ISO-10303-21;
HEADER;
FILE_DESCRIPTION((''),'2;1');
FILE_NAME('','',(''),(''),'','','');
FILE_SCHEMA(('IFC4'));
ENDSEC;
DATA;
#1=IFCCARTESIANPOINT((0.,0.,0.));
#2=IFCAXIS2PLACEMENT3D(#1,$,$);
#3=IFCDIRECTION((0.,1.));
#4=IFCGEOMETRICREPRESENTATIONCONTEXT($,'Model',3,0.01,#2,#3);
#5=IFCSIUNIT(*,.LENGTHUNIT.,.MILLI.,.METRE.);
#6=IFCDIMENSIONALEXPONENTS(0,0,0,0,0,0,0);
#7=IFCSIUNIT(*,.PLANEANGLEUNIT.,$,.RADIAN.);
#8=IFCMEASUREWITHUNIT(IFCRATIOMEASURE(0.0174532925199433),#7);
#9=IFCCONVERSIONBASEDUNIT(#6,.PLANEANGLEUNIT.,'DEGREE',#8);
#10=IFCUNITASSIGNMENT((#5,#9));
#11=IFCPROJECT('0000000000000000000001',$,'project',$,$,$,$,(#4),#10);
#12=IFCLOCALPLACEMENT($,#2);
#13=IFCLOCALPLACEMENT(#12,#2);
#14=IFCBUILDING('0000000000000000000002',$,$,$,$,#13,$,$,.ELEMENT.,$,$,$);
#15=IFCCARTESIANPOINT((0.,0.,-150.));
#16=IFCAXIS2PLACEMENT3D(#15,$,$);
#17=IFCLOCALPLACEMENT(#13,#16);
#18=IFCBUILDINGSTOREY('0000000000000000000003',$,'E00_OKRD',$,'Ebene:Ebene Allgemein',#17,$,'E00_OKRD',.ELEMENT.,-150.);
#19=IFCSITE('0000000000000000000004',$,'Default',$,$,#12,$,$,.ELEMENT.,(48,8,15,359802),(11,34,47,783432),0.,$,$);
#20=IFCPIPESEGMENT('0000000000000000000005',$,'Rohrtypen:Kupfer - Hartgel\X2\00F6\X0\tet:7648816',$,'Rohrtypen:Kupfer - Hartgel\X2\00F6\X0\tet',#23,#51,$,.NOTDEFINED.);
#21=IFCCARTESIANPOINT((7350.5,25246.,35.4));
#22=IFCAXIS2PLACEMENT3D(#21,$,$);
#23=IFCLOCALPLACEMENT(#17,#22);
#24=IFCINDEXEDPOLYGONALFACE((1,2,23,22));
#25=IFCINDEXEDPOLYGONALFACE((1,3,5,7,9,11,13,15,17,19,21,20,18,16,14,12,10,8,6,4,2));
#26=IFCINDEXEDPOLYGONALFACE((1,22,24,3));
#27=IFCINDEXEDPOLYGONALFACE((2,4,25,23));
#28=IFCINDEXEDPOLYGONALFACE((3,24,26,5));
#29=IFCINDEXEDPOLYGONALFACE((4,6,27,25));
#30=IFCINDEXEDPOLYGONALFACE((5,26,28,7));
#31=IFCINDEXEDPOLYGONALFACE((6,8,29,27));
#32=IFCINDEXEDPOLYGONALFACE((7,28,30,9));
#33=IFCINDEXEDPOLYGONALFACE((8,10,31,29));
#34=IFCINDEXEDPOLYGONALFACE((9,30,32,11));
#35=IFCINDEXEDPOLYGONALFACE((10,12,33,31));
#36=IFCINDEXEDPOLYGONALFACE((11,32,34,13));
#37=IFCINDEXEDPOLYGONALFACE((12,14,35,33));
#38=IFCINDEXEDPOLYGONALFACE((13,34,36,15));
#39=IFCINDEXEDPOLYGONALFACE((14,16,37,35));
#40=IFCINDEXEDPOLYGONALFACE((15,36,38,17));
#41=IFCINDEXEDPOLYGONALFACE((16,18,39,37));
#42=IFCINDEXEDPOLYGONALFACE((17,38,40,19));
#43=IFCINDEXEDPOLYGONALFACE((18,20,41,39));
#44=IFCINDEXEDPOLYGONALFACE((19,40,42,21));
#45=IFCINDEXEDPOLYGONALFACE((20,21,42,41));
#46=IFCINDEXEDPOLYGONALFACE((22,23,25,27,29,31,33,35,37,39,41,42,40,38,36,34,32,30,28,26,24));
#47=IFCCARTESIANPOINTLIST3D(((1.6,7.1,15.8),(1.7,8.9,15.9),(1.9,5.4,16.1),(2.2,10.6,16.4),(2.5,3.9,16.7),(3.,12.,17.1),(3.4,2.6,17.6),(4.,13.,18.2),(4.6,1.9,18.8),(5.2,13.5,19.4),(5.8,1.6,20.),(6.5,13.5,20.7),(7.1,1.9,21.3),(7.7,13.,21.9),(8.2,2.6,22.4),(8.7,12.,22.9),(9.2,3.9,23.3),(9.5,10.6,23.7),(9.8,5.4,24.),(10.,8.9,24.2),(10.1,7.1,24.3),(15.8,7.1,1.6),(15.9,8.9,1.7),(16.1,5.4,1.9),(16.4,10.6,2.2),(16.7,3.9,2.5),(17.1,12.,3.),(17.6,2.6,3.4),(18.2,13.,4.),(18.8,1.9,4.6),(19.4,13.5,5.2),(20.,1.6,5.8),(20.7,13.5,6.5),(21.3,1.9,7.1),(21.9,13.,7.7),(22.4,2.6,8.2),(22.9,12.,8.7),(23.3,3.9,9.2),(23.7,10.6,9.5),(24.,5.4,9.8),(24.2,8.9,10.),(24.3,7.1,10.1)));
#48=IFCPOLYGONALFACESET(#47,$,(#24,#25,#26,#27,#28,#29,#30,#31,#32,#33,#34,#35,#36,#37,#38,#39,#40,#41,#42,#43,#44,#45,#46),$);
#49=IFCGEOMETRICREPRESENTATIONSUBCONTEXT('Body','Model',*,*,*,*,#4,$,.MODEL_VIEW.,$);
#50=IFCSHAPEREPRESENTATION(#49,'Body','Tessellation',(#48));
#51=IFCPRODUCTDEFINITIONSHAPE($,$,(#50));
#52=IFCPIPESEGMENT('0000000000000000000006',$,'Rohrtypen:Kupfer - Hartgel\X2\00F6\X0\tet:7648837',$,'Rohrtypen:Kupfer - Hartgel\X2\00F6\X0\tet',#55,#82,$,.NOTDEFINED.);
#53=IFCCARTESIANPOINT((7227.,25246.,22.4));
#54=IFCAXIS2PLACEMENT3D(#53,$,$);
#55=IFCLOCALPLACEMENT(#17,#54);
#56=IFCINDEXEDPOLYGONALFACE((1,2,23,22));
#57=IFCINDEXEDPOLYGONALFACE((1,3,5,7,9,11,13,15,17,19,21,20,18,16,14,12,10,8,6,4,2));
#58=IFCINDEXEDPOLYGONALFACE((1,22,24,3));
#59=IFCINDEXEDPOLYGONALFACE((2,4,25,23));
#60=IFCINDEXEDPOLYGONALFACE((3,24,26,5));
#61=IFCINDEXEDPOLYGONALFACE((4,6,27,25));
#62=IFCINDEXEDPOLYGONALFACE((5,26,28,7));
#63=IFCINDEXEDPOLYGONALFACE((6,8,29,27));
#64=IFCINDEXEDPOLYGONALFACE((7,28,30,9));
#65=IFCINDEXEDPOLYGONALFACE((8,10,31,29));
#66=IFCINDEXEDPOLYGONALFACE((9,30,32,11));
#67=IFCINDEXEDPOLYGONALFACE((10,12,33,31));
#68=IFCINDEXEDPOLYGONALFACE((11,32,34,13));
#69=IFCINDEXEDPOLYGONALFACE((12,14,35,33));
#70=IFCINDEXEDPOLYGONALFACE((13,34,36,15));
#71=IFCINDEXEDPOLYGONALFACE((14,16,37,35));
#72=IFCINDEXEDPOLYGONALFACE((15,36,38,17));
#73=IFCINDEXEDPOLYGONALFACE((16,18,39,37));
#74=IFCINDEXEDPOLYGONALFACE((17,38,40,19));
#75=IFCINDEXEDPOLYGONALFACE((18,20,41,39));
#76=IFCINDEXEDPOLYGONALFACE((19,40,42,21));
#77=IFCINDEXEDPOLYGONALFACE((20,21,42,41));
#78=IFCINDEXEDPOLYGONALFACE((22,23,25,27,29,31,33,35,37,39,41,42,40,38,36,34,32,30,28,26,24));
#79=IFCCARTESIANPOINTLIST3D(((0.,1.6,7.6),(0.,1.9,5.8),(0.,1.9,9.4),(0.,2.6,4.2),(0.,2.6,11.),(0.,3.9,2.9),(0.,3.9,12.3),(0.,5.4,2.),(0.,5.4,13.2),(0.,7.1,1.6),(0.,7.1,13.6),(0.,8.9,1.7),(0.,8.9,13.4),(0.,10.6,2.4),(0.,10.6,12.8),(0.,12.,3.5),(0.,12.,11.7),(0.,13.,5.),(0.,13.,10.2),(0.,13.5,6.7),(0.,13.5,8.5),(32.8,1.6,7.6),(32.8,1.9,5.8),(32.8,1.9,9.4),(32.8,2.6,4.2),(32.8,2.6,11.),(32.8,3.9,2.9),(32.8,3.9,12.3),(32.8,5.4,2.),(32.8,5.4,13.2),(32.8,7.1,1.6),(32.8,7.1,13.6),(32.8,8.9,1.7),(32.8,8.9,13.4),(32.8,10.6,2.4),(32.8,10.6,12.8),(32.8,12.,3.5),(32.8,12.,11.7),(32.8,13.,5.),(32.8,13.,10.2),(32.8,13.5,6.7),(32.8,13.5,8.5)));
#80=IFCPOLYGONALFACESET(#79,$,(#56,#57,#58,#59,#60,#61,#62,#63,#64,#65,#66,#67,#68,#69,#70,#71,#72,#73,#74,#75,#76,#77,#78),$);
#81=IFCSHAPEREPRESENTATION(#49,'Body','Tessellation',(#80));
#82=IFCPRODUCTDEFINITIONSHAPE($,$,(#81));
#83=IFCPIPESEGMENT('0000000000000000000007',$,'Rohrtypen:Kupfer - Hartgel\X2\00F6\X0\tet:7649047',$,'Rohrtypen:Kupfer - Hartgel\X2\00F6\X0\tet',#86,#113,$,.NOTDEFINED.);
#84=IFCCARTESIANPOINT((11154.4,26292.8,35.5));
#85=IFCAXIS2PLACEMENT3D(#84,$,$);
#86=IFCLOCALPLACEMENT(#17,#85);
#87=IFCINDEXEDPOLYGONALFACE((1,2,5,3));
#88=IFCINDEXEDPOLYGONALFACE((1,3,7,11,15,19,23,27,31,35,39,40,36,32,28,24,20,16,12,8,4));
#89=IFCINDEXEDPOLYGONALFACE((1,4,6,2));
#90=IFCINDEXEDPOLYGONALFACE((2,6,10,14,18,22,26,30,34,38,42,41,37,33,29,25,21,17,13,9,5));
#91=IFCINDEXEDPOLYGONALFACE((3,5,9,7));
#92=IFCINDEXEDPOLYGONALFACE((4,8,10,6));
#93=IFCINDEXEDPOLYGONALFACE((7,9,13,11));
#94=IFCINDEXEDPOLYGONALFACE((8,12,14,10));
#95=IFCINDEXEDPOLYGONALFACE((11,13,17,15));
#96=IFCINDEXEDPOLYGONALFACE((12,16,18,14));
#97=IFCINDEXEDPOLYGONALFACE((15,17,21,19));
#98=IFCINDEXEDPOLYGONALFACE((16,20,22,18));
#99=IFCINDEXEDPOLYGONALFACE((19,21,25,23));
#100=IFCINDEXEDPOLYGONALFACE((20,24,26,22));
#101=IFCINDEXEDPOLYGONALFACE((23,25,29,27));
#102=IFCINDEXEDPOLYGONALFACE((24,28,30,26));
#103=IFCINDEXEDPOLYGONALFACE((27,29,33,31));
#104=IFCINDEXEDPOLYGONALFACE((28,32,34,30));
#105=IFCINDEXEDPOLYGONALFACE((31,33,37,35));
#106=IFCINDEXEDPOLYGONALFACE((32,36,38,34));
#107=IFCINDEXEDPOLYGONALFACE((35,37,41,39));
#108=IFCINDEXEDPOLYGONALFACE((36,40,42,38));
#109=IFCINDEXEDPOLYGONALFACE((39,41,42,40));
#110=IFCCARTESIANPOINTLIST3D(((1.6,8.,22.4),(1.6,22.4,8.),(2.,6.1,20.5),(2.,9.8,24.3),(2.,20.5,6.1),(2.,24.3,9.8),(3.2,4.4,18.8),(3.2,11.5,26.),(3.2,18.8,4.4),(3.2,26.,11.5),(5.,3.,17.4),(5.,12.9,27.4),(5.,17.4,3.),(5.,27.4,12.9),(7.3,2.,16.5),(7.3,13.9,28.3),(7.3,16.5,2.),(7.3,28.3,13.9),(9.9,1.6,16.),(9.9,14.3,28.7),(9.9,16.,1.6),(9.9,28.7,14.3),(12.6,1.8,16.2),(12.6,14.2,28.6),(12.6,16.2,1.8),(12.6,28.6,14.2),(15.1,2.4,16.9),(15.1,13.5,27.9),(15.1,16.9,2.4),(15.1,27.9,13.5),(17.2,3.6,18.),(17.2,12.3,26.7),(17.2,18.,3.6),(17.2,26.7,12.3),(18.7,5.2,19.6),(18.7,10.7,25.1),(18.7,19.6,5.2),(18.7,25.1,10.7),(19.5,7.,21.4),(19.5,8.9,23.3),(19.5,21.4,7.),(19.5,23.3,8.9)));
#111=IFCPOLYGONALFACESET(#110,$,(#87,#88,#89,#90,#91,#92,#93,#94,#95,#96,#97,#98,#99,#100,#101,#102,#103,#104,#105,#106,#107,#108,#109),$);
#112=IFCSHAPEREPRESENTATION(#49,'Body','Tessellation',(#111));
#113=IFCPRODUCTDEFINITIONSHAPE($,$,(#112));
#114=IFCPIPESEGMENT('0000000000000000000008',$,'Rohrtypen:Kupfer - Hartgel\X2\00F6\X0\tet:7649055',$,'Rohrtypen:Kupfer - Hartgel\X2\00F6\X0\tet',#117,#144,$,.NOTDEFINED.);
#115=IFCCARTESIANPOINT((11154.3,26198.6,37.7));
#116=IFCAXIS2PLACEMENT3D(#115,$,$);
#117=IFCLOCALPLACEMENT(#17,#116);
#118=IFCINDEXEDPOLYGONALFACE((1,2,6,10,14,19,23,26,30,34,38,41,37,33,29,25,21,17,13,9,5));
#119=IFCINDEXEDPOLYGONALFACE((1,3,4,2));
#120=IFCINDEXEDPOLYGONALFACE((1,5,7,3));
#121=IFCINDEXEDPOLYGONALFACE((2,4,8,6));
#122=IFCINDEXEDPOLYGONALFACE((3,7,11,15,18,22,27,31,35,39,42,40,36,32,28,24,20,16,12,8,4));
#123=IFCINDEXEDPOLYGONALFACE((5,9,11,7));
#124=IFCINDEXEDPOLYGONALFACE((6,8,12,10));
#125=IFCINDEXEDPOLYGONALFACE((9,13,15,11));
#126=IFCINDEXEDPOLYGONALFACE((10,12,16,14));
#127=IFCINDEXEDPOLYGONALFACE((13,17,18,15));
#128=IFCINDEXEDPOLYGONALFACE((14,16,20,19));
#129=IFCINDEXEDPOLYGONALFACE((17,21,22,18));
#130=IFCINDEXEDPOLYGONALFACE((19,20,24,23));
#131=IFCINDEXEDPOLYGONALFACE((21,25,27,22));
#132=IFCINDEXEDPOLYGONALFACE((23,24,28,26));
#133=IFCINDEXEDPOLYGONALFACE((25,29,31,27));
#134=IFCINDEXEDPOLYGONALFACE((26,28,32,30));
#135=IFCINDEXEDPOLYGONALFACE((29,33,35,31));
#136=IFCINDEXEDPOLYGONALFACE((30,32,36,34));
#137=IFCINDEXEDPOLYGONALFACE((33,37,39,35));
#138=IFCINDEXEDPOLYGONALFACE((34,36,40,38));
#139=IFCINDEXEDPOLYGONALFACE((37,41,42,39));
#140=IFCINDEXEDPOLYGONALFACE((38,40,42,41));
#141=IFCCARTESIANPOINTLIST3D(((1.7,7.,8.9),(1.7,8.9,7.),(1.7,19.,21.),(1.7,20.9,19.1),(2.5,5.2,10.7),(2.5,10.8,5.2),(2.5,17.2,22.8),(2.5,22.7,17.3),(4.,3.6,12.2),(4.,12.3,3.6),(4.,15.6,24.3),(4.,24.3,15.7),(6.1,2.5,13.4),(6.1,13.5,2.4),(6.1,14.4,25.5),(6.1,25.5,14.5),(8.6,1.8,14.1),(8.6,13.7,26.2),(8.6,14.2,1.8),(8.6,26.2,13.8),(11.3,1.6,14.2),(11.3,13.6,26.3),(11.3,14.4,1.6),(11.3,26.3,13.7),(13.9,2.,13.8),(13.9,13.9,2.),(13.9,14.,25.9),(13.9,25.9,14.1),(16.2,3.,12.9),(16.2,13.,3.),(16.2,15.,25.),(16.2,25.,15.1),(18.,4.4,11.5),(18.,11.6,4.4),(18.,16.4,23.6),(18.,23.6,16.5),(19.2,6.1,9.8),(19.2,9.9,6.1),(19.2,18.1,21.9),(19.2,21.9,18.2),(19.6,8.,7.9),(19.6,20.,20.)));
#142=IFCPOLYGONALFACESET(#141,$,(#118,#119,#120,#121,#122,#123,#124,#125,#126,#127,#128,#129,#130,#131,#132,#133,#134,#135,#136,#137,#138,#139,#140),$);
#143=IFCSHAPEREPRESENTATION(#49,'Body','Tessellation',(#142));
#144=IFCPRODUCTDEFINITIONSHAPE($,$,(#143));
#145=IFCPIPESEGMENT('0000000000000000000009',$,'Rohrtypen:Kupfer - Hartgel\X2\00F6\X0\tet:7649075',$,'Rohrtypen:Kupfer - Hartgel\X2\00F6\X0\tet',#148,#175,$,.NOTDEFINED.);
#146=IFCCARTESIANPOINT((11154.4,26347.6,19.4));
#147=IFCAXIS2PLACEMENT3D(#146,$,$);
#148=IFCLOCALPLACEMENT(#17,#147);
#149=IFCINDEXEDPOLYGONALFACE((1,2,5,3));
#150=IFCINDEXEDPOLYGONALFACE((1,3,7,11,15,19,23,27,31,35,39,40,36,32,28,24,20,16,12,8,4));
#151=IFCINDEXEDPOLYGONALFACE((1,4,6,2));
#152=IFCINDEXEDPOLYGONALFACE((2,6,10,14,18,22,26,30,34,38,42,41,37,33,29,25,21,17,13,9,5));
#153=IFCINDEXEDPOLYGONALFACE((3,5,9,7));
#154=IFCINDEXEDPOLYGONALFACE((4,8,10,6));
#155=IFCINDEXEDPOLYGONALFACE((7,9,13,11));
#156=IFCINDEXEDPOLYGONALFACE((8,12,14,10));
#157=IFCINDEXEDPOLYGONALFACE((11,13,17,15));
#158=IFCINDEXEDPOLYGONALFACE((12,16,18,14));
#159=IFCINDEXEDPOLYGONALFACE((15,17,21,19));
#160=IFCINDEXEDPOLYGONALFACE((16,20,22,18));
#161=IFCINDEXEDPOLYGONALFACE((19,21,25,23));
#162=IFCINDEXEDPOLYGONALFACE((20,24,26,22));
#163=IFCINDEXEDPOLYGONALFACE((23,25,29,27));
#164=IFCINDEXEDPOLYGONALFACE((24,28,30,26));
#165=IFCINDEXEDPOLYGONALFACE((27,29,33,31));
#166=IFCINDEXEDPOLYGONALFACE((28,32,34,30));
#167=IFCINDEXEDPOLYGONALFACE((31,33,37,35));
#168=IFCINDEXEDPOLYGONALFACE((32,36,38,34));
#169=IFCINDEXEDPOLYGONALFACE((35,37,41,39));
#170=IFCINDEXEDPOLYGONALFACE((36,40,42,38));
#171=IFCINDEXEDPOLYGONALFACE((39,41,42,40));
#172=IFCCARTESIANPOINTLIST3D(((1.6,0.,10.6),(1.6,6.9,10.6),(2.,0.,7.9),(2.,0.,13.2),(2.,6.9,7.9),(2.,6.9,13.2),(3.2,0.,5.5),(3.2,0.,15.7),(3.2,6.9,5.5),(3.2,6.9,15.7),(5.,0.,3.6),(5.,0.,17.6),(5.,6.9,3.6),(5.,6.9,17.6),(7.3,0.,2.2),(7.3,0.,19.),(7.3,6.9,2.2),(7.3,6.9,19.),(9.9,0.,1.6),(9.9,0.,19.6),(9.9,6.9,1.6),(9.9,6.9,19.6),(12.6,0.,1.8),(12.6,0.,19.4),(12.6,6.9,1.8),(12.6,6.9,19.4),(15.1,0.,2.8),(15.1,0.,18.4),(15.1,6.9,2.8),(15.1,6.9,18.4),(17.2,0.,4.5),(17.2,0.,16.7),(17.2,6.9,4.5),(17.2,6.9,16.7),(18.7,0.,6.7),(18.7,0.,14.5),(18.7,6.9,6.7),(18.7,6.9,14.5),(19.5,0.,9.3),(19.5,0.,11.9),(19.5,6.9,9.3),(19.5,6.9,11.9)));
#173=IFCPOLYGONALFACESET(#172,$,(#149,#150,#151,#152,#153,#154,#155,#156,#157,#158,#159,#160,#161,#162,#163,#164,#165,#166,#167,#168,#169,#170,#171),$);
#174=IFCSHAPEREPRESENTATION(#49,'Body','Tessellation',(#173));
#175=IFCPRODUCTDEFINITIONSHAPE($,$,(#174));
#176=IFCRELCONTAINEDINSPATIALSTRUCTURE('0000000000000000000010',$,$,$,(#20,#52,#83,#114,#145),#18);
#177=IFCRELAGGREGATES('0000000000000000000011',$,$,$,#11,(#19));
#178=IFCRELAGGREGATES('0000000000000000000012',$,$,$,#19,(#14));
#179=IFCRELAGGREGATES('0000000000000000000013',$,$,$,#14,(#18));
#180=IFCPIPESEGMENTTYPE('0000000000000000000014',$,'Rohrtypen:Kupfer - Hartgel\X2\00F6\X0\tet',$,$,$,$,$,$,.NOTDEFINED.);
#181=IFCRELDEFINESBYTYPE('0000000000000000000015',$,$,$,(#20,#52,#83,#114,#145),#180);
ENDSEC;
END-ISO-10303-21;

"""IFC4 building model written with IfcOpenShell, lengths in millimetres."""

from ifc_helpers import new_model, entity, si_unit, converted_unit, direction, frame, frame_2d, origin, origin_2d_with_axis, place, context, subcontext, project, spatial, circle, extrude, type_object, element, save


model = new_model("IFC4")

# Units and contexts
model_context = context("Model", 3, precision=0.01, world=origin(), true_north=direction((0.0, 1.0)))
body_context = subcontext(model_context, "Body", "Model", "MODEL_VIEW")
ifc_project = project(units=[si_unit("LENGTHUNIT", "METRE", prefix="MILLI"), converted_unit("PLANEANGLEUNIT", "DEGREE", entity("IfcRatioMeasure", 0.0174532925199433), si_unit("PLANEANGLEUNIT", "RADIAN"), dimensions=[0, 0, 0, 0, 0, 0, 0])], contexts=[model_context])

# Site, building, storey
site_placement = place(None, origin())
site = spatial("IfcSite", under=ifc_project, at=site_placement, Name="Default", CompositionType="ELEMENT", RefLatitude=(48, 8, 15, 359802), RefLongitude=(11, 34, 47, 783432), RefElevation=0.0)
building_placement = place(site_placement, origin())
building = spatial("IfcBuilding", under=site, at=building_placement, CompositionType="ELEMENT")
storey_placement = place(building_placement, frame((0.0, 0.0, -150.0)))
storey = spatial("IfcBuildingStorey", under=building, at=storey_placement, Name="E00_OKRD", ObjectType="Ebene:Ebene Allgemein", LongName="E00_OKRD", CompositionType="ELEMENT", Elevation=-150.0)

# Pipe segments
pipe_segment_type = type_object("IfcPipeSegmentType", Name="Rohrtypen:Kupfer - Hartgelötet", PredefinedType="NOTDEFINED")
pipe_segment_1_placement = place(storey_placement, frame((7350.5, 25246.0, 35.4)))
element("IfcPipeSegment", 1, at=pipe_segment_1_placement, inside=storey, type_object=pipe_segment_type, Name="Rohrtypen:Kupfer - Hartgelötet:7648816", ObjectType="Rohrtypen:Kupfer - Hartgelötet", PredefinedType="NOTDEFINED", context=body_context, shape_type="SweptSolid", body=[
    extrude(circle(Radius=6.0, at=frame_2d((0.0, 0.0), x_axis=(1.0, 0.0))), frame((20.0, 7.6, 5.8), z_axis=(-0.707107, 0.0, 0.707107), x_axis=(0.0, -1.0, 0.0)), (0.0, 0.0, 1.0), 20.1),
])
pipe_segment_2_placement = place(storey_placement, frame((7227.0, 25246.0, 22.4)))
element("IfcPipeSegment", 2, at=pipe_segment_2_placement, inside=storey, type_object=pipe_segment_type, Name="Rohrtypen:Kupfer - Hartgelötet:7648837", ObjectType="Rohrtypen:Kupfer - Hartgelötet", PredefinedType="NOTDEFINED", context=body_context, shape_type="SweptSolid", body=[
    extrude(circle(Radius=6.0, at=origin_2d_with_axis()), frame((0.0, 7.6, 7.6), z_axis=(1.0, 0.0, 0.0), x_axis=(0.0, -1.0, 0.0)), (0.0, 0.0, 1.0), 32.8),
])
pipe_segment_3_placement = place(storey_placement, frame((11154.4, 26292.8, 35.5)))
element("IfcPipeSegment", 3, at=pipe_segment_3_placement, inside=storey, type_object=pipe_segment_type, Name="Rohrtypen:Kupfer - Hartgelötet:7649047", ObjectType="Rohrtypen:Kupfer - Hartgelötet", PredefinedType="NOTDEFINED", context=body_context, shape_type="SweptSolid", body=[
    extrude(circle(Radius=9.0, at=origin_2d_with_axis()), frame((10.6, 8.0, 22.4), z_axis=(0.0, 0.707107, -0.707107), x_axis=(-1.0, 0.0, 0.0)), (0.0, 0.0, 1.0), 20.4),
])
pipe_segment_4_placement = place(storey_placement, frame((11154.3, 26198.6, 37.7)))
element("IfcPipeSegment", 4, at=pipe_segment_4_placement, inside=storey, type_object=pipe_segment_type, Name="Rohrtypen:Kupfer - Hartgelötet:7649055", ObjectType="Rohrtypen:Kupfer - Hartgelötet", PredefinedType="NOTDEFINED", context=body_context, shape_type="SweptSolid", body=[
    extrude(circle(Radius=9.0, at=origin_2d_with_axis()), frame((10.6, 8.0, 7.9), z_axis=(0.0, 0.70394, 0.71026), x_axis=(1.0, 0.0, 0.0)), (0.0, 0.0, 1.0), 17.0),
])
pipe_segment_5_placement = place(storey_placement, frame((11154.4, 26347.6, 19.4)))
element("IfcPipeSegment", 5, at=pipe_segment_5_placement, inside=storey, type_object=pipe_segment_type, Name="Rohrtypen:Kupfer - Hartgelötet:7649075", ObjectType="Rohrtypen:Kupfer - Hartgelötet", PredefinedType="NOTDEFINED", context=body_context, shape_type="SweptSolid", body=[
    extrude(circle(Radius=9.0, at=frame_2d((0.0, 0.0), x_axis=(1.0, 0.0))), frame((10.6, 0.0, 10.6), z_axis=(0.0, 1.0, 0.0), x_axis=(-1.0, 0.0, 0.0)), (0.0, 0.0, 1.0), 6.9),
])

save(model, "model.ifc")
